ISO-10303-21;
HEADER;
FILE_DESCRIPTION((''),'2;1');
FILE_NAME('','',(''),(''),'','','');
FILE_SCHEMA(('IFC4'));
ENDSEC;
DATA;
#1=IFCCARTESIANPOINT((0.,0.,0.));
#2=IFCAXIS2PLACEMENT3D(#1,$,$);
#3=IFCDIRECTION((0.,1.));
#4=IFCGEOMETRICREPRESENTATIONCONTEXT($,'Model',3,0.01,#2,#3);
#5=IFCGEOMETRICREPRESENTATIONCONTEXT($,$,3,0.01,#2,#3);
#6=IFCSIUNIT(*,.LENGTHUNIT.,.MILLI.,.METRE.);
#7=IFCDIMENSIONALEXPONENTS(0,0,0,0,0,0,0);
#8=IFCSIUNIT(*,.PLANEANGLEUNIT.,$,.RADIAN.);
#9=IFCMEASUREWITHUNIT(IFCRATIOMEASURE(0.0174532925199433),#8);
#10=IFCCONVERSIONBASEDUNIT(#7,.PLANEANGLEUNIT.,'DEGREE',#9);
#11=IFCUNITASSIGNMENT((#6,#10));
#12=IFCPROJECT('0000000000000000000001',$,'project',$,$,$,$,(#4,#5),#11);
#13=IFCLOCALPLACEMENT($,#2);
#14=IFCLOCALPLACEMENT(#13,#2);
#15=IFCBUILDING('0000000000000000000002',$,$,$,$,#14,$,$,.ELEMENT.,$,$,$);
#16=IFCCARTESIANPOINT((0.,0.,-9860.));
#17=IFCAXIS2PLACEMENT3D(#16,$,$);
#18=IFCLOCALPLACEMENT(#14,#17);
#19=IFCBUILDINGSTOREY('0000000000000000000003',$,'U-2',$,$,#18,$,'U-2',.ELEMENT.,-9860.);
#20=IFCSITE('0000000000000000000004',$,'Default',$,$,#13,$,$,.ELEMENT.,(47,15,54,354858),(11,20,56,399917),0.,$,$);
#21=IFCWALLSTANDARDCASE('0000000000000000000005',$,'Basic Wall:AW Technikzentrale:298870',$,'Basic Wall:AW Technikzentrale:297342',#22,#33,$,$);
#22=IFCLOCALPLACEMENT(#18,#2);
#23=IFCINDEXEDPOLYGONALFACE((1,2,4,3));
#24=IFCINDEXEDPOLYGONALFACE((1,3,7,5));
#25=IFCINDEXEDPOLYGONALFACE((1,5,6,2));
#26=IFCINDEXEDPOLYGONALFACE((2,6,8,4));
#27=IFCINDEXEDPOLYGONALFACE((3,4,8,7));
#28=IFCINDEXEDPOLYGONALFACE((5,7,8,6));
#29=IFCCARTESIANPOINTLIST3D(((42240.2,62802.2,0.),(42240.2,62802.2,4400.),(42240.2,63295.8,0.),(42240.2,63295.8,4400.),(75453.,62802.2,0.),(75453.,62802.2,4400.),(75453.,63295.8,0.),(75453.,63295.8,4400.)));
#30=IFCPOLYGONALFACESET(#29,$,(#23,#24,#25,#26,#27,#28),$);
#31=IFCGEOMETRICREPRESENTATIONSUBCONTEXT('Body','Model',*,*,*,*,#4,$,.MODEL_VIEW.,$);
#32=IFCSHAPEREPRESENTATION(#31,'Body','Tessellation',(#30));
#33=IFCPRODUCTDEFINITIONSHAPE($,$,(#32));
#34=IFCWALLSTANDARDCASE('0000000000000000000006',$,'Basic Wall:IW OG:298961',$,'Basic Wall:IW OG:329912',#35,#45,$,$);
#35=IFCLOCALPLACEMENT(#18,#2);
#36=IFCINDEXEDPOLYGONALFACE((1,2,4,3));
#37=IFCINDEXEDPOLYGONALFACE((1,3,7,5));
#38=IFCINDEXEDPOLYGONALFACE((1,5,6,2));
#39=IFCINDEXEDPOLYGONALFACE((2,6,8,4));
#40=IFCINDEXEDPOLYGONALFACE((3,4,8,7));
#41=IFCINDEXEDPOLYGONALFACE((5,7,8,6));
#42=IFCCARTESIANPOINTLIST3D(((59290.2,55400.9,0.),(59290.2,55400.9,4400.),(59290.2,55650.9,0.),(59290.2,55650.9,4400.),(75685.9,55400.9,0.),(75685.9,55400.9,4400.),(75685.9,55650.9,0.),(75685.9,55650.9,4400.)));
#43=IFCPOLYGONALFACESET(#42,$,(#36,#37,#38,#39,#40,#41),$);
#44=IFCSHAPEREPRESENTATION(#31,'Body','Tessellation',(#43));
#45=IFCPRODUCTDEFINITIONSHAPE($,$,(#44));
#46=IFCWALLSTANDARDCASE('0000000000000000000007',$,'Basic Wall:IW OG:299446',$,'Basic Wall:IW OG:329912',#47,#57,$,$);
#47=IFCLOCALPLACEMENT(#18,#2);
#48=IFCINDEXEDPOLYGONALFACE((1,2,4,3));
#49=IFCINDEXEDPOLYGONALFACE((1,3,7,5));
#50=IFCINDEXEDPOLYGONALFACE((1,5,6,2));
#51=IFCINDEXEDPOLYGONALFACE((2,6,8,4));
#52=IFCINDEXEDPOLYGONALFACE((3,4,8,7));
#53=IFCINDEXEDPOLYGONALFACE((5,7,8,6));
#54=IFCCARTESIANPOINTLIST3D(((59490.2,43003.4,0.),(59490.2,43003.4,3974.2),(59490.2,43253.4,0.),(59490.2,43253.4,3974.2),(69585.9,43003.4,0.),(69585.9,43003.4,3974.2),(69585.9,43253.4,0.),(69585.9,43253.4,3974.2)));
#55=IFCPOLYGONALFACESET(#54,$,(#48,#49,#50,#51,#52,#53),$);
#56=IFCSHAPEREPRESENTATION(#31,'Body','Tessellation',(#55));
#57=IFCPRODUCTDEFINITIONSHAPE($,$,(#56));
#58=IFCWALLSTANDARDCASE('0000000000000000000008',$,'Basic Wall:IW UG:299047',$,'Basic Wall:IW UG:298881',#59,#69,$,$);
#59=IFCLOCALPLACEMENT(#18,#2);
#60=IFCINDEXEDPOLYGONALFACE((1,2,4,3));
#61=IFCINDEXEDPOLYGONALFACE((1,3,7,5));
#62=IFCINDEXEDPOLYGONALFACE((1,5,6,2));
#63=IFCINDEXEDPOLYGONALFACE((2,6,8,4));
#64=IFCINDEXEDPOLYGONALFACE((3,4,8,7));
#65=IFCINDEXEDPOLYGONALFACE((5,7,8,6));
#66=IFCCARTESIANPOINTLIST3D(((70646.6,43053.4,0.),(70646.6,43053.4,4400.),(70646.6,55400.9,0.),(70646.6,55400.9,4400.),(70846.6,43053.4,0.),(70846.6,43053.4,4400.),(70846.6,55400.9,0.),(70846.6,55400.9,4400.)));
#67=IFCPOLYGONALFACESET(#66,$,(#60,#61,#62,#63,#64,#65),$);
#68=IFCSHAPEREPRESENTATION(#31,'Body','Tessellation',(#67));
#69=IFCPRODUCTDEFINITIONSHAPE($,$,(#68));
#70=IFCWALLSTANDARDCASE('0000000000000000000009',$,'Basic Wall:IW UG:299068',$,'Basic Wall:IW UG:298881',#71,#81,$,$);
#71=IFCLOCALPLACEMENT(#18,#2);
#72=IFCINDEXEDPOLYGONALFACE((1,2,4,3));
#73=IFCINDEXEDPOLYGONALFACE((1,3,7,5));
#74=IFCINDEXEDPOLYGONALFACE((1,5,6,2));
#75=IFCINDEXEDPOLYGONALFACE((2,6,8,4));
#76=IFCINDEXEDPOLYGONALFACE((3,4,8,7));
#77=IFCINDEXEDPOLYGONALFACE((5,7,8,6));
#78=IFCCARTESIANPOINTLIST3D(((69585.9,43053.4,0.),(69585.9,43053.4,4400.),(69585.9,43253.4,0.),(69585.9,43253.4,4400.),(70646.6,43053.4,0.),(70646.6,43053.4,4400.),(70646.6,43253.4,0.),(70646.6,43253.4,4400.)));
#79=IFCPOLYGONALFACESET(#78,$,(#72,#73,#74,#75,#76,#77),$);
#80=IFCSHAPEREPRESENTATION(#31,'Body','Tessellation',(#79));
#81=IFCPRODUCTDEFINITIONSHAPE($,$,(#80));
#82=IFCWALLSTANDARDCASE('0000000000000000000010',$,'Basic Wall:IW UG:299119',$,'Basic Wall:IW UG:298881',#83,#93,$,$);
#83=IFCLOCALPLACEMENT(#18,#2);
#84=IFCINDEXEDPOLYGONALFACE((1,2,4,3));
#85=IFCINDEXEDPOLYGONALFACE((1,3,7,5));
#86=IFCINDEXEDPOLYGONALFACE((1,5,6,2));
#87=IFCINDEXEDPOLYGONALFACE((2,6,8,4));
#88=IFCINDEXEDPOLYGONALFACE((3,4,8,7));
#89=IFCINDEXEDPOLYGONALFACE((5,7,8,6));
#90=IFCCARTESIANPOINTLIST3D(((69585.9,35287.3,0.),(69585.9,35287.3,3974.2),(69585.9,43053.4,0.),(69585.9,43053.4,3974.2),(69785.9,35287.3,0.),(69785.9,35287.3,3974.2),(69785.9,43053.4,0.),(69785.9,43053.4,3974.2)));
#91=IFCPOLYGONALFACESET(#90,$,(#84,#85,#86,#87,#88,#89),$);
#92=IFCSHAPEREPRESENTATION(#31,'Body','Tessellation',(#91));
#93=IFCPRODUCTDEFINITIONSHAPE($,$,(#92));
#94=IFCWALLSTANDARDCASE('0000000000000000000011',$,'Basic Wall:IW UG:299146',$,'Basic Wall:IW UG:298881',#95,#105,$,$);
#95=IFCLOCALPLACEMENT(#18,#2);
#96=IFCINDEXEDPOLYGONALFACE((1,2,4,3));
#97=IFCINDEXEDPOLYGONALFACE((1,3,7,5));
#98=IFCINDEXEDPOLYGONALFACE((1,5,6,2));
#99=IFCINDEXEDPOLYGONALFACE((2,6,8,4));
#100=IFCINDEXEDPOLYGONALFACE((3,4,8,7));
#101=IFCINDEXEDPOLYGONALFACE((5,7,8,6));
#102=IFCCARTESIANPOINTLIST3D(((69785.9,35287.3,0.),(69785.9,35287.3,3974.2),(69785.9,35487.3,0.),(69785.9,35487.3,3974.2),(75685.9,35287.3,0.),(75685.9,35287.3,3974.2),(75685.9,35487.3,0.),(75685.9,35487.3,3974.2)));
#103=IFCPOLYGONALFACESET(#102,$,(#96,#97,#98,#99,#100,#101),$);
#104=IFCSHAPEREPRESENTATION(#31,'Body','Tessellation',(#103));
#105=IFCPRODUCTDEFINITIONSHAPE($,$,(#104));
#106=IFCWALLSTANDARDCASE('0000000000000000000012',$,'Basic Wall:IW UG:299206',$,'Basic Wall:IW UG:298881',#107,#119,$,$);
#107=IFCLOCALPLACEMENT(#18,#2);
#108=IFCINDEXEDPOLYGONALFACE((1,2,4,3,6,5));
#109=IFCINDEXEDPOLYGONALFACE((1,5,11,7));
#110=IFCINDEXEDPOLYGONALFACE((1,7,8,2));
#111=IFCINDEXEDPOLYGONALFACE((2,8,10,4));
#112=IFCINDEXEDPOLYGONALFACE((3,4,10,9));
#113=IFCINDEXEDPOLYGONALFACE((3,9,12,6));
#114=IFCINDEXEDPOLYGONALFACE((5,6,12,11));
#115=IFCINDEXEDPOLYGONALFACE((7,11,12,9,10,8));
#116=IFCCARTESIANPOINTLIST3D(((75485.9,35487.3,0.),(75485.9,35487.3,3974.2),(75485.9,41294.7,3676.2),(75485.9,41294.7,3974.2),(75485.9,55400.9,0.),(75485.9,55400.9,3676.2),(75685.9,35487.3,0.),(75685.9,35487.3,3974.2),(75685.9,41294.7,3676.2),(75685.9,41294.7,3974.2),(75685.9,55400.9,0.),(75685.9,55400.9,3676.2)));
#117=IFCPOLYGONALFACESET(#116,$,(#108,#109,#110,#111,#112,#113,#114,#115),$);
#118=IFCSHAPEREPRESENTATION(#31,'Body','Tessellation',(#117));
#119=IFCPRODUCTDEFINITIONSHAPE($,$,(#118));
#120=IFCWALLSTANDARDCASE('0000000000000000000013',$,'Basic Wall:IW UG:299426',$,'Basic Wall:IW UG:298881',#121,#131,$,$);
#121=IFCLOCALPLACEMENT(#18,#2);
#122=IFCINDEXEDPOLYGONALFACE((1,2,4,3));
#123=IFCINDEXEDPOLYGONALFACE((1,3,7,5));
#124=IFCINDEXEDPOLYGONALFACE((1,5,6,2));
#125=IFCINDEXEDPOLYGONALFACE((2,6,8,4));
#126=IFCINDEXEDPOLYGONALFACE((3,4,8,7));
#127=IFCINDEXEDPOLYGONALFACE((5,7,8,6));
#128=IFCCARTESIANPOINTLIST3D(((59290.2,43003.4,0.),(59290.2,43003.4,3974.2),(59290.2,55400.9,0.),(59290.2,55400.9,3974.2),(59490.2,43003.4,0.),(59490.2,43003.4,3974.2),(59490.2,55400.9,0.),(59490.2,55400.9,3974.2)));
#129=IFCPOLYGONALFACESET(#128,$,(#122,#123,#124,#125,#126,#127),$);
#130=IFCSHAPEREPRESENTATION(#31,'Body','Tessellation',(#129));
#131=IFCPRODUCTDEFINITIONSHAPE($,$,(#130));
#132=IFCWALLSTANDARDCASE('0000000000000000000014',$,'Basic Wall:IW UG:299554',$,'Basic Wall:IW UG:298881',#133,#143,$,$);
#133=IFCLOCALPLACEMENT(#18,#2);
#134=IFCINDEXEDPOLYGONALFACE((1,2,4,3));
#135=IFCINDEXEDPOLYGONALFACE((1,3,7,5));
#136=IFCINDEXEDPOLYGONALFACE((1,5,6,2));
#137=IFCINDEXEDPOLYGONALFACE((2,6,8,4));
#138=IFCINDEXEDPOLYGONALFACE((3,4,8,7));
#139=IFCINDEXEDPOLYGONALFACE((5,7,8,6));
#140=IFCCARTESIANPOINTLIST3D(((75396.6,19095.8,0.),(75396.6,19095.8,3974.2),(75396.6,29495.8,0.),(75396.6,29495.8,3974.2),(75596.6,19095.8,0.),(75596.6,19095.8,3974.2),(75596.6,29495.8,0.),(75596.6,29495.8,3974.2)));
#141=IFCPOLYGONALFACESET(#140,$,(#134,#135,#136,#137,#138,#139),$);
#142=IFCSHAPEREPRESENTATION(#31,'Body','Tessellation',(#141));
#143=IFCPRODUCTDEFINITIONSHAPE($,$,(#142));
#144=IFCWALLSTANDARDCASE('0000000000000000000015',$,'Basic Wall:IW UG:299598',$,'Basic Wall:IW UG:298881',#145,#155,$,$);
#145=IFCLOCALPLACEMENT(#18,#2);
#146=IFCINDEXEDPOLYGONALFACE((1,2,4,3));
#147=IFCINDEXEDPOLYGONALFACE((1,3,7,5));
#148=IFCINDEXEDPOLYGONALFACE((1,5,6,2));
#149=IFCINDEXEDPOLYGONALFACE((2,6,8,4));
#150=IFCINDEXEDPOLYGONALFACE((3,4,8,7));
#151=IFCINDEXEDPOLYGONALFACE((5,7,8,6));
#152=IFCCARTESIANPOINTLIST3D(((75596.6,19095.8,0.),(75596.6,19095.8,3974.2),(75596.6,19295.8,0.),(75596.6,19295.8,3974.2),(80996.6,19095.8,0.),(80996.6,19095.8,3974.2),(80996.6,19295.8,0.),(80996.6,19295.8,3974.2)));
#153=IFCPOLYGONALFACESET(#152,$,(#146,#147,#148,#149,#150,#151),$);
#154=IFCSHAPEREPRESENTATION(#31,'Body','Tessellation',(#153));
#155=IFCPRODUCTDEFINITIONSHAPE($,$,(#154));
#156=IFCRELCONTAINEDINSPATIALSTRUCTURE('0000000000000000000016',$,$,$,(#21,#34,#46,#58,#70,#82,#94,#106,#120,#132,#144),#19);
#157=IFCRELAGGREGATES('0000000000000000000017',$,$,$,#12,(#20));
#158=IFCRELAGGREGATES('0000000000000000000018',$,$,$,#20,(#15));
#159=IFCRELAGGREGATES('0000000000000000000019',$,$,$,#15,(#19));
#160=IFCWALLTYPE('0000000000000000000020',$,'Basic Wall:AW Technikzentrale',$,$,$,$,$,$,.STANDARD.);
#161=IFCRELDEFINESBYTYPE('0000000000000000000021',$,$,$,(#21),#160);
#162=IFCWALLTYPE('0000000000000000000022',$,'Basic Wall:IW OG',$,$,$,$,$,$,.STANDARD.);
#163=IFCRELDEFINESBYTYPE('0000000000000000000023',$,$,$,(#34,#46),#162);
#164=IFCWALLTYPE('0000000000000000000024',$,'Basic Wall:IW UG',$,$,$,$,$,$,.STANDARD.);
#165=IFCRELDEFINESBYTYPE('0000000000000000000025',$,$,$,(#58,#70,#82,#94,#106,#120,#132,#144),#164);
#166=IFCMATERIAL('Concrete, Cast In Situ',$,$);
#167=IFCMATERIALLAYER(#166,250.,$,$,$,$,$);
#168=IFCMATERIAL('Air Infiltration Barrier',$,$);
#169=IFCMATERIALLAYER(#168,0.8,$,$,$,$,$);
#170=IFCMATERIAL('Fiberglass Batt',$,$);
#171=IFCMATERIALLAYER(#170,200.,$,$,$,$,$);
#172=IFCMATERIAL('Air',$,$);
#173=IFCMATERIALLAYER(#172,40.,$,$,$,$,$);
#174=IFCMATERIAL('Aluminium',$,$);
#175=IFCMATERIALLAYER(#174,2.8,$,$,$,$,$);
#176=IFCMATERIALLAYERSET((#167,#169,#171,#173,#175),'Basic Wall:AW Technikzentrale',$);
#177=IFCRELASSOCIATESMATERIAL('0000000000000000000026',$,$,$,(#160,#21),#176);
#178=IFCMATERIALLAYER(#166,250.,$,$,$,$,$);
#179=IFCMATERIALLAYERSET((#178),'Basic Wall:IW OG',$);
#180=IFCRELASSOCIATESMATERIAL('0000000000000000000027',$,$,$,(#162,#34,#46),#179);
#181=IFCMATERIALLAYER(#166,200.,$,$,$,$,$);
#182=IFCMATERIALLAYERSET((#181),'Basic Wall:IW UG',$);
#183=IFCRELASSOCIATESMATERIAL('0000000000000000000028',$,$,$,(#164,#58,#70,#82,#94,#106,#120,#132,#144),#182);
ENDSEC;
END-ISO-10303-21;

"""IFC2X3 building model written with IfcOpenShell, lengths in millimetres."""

from ifc_helpers import new_model, entity, si_unit, converted_unit, direction, frame, frame_2d, origin, place, context, subcontext, project, spatial, polyline, rectangle, extrude, clip, bounded_halfspace, material, layer, layer_set, layer_usage, type_object, element, save


model = new_model("IFC2X3")

# Units and contexts
model_context = context("Model", 3, precision=0.01, world=origin(), true_north=direction((0.0, 1.0)))
context_of_model = context(None, 3, precision=0.01, world=origin(), true_north=direction((0.0, 1.0)))
body_context = subcontext(model_context, "Body", "Model", "MODEL_VIEW")
ifc_project = project(units=[si_unit("LENGTHUNIT", "METRE", prefix="MILLI"), converted_unit("PLANEANGLEUNIT", "DEGREE", entity("IfcRatioMeasure", 0.0174532925199433), si_unit("PLANEANGLEUNIT", "RADIAN"), dimensions=[0, 0, 0, 0, 0, 0, 0])], contexts=[model_context, context_of_model])

# Site, building, storey
site_placement = place(None, origin())
site = spatial("IfcSite", under=ifc_project, at=site_placement, Name="Default", CompositionType="ELEMENT", RefLatitude=(47, 15, 54, 354858), RefLongitude=(11, 20, 56, 399917), RefElevation=0.0)
building_placement = place(site_placement, origin())
building = spatial("IfcBuilding", under=site, at=building_placement, CompositionType="ELEMENT")
storey_placement = place(building_placement, frame((0.0, 0.0, -9860.0)))
storey = spatial("IfcBuildingStorey", under=building, at=storey_placement, Name="U-2", LongName="U-2", CompositionType="ELEMENT", Elevation=-9860.0)

# Shared definitions
ifc_material_1 = material(Name="Air Infiltration Barrier")
ifc_material_2 = material(Name="Fiberglass Batt")

# Walls
ifc_material_3 = material(Name="Concrete, Cast In Situ")
ifc_layer_1 = layer(ifc_material_3, 250.0)
ifc_layer_2 = layer(ifc_material_1, 0.8)
ifc_layer_3 = layer(ifc_material_2, 200.0)
ifc_material_4 = material(Name="Air")
ifc_layer_4 = layer(ifc_material_4, 40.0)
ifc_material_5 = material(Name="Aluminium")
ifc_layer_5 = layer(ifc_material_5, 2.8)
ifc_layer_set_1 = layer_set([ifc_layer_1, ifc_layer_2, ifc_layer_3, ifc_layer_4, ifc_layer_5], Name="Basic Wall:AW Technikzentrale")
wall_type_1 = type_object("IfcWallType", Name="Basic Wall:AW Technikzentrale", PredefinedType="STANDARD", material=ifc_layer_set_1)
ifc_layer_usage_1 = layer_usage(ifc_layer_set_1, "AXIS2", "NEGATIVE", 246.8)
wall_1_placement = place(storey_placement, frame((75453.0, 63049.0, 0.0), z_axis=(0.0, 0.0, 1.0), x_axis=(-1.0, 0.0, 0.0)))
element("IfcWallStandardCase", 1, at=wall_1_placement, inside=storey, type_object=wall_type_1, material=ifc_layer_usage_1, Name="Basic Wall:AW Technikzentrale:298870", ObjectType="Basic Wall:AW Technikzentrale:297342", context=body_context, shape_type="SweptSolid", body=[
    extrude(rectangle(XDim=33212.8, YDim=493.6, at=frame_2d((16606.4, 0.0), x_axis=(-1.0, 0.0))), origin(), (0.0, 0.0, 1.0), 4400.0),
])
ifc_layer_6 = layer(ifc_material_3, 250.0)
ifc_layer_set_2 = layer_set([ifc_layer_6], Name="Basic Wall:IW OG")
ifc_layer_usage_2 = layer_usage(ifc_layer_set_2, "AXIS2", "NEGATIVE", 125.0)
wall_type_2 = type_object("IfcWallType", Name="Basic Wall:IW OG", PredefinedType="STANDARD", material=ifc_layer_set_2)
wall_2_placement = place(storey_placement, frame((75685.9, 55525.9, 0.0), z_axis=(0.0, 0.0, 1.0), x_axis=(-1.0, 0.0, 0.0)))
element("IfcWallStandardCase", 2, at=wall_2_placement, inside=storey, type_object=wall_type_2, material=ifc_layer_usage_2, Name="Basic Wall:IW OG:298961", ObjectType="Basic Wall:IW OG:329912", context=body_context, shape_type="SweptSolid", body=[
    extrude(rectangle(XDim=16395.7, YDim=250.0, at=frame_2d((8197.9, 0.0), x_axis=(-1.0, 0.0))), origin(), (0.0, 0.0, 1.0), 4400.0),
])
ifc_layer_usage_3 = layer_usage(ifc_layer_set_2, "AXIS2", "POSITIVE", -125.0)
wall_3_placement = place(storey_placement, frame((59490.2, 43128.4, 0.0)))
element("IfcWallStandardCase", 3, at=wall_3_placement, inside=storey, type_object=wall_type_2, material=ifc_layer_usage_3, Name="Basic Wall:IW OG:299446", ObjectType="Basic Wall:IW OG:329912", context=body_context, shape_type="Clipping", body=[
    clip(extrude(rectangle(XDim=10095.7, YDim=250.0, at=frame_2d((5047.9, 0.0), x_axis=(-1.0, 0.0))), origin(), (0.0, 0.0, 1.0), 3974.2), bounded_halfspace(frame((0.0, -125.0, 3974.2), z_axis=(0.0, 0.0, -1.0), x_axis=(0.0, 1.0, 0.0)), True, frame((0.0, -125.0, 3974.2)), polyline([(0.0, 0.0), (10095.7, 0.0), (10095.7, 50.0), (10095.7, 250.0), (0.0, 250.0), (0.0, 0.0)]))),
])
ifc_layer_7 = layer(ifc_material_3, 200.0)
ifc_layer_set_3 = layer_set([ifc_layer_7], Name="Basic Wall:IW UG")
ifc_layer_usage_4 = layer_usage(ifc_layer_set_3, "AXIS2", "NEGATIVE", 100.0)
wall_type_3 = type_object("IfcWallType", Name="Basic Wall:IW UG", PredefinedType="STANDARD", material=ifc_layer_set_3)
wall_4_placement = place(storey_placement, frame((70746.6, 55400.9, 0.0), z_axis=(0.0, 0.0, 1.0), x_axis=(0.0, -1.0, 0.0)))
element("IfcWallStandardCase", 4, at=wall_4_placement, inside=storey, type_object=wall_type_3, material=ifc_layer_usage_4, Name="Basic Wall:IW UG:299047", ObjectType="Basic Wall:IW UG:298881", context=body_context, shape_type="SweptSolid", body=[
    extrude(rectangle(XDim=12347.4, YDim=200.0, at=frame_2d((6173.7, 0.0), x_axis=(-1.0, 0.0))), origin(), (0.0, 0.0, 1.0), 4400.0),
])
ifc_layer_usage_5 = layer_usage(ifc_layer_set_3, "AXIS2", "NEGATIVE", 100.0)
wall_5_placement = place(storey_placement, frame((70646.6, 43153.4, 0.0), z_axis=(0.0, 0.0, 1.0), x_axis=(-1.0, 0.0, 0.0)))
element("IfcWallStandardCase", 5, at=wall_5_placement, inside=storey, type_object=wall_type_3, material=ifc_layer_usage_5, Name="Basic Wall:IW UG:299068", ObjectType="Basic Wall:IW UG:298881", context=body_context, shape_type="SweptSolid", body=[
    extrude(rectangle(XDim=1060.7, YDim=200.0, at=frame_2d((530.3, 0.0), x_axis=(-1.0, 0.0))), origin(), (0.0, 0.0, 1.0), 4400.0),
])
ifc_layer_usage_6 = layer_usage(ifc_layer_set_3, "AXIS2", "NEGATIVE", 100.0)
wall_6_placement = place(storey_placement, frame((69685.9, 43053.4, 0.0), z_axis=(0.0, 0.0, 1.0), x_axis=(0.0, -1.0, 0.0)))
element("IfcWallStandardCase", 6, at=wall_6_placement, inside=storey, type_object=wall_type_3, material=ifc_layer_usage_6, Name="Basic Wall:IW UG:299119", ObjectType="Basic Wall:IW UG:298881", context=body_context, shape_type="Clipping", body=[
    clip(extrude(rectangle(XDim=7766.1, YDim=200.0, at=frame_2d((3883.0, 0.0), x_axis=(-1.0, 0.0))), origin(), (0.0, 0.0, 1.0), 3974.2), bounded_halfspace(frame((0.0, -100.0, 3974.2), z_axis=(0.0, 0.0, -1.0), x_axis=(-1.0, 0.0, 0.0)), True, frame((0.0, -100.0, 3974.2)), polyline([(0.0, 0.0), (50.0, 0.0), (7766.1, 0.0), (7766.1, 200.0), (7566.1, 200.0), (0.0, 200.0), (0.0, 0.0)]))),
])
ifc_layer_usage_7 = layer_usage(ifc_layer_set_3, "AXIS2", "NEGATIVE", 100.0)
wall_7_placement = place(storey_placement, frame((69785.9, 35387.3, 0.0)))
element("IfcWallStandardCase", 7, at=wall_7_placement, inside=storey, type_object=wall_type_3, material=ifc_layer_usage_7, Name="Basic Wall:IW UG:299146", ObjectType="Basic Wall:IW UG:298881", context=body_context, shape_type="Clipping", body=[
    clip(extrude(rectangle(XDim=5900.0, YDim=200.0, at=frame_2d((2950.0, 0.0), x_axis=(-1.0, 0.0))), origin(), (0.0, 0.0, 1.0), 3974.2), bounded_halfspace(frame((0.0, -100.0, 3974.2), z_axis=(0.0, 0.0, -1.0), x_axis=(0.0, 1.0, 0.0)), True, frame((0.0, -100.0, 3974.2)), polyline([(0.0, 0.0), (5900.0, 0.0), (5900.0, 200.0), (5700.0, 200.0), (0.0, 200.0), (0.0, 0.0)]))),
])
ifc_layer_usage_8 = layer_usage(ifc_layer_set_3, "AXIS2", "NEGATIVE", 100.0)
wall_8_placement = place(storey_placement, frame((75585.9, 35487.3, 0.0), z_axis=(0.0, 0.0, 1.0), x_axis=(0.0, 1.0, 0.0)))
element("IfcWallStandardCase", 8, at=wall_8_placement, inside=storey, type_object=wall_type_3, material=ifc_layer_usage_8, Name="Basic Wall:IW UG:299206", ObjectType="Basic Wall:IW UG:298881", context=body_context, shape_type="Clipping", body=[
    clip(clip(extrude(rectangle(XDim=19913.5, YDim=200.0, at=frame_2d((9956.8, 0.0), x_axis=(-1.0, 0.0))), origin(), (0.0, 0.0, 1.0), 3974.2), bounded_halfspace(frame((0.0, -100.0, 3974.2), z_axis=(0.0, 0.0, -1.0), x_axis=(1.0, 0.0, 0.0)), True, frame((0.0, -100.0, 3974.2)), polyline([(0.0, 0.0), (5807.3, 0.0), (5807.3, 200.0), (0.0, 200.0), (0.0, 0.0)]))), bounded_halfspace(frame((5807.3, -100.0, 3676.2), z_axis=(0.0, 0.0, 1.0), x_axis=(0.0, 1.0, 0.0)), False, frame((5807.3, -100.0, 3676.2)), polyline([(0.0, 0.0), (14106.2, 0.0), (14106.2, 200.0), (0.0, 200.0), (0.0, 0.0)]))),
])
ifc_layer_usage_9 = layer_usage(ifc_layer_set_3, "AXIS2", "NEGATIVE", 100.0)
wall_9_placement = place(storey_placement, frame((59390.2, 55400.9, 0.0), z_axis=(0.0, 0.0, 1.0), x_axis=(0.0, -1.0, 0.0)))
element("IfcWallStandardCase", 9, at=wall_9_placement, inside=storey, type_object=wall_type_3, material=ifc_layer_usage_9, Name="Basic Wall:IW UG:299426", ObjectType="Basic Wall:IW UG:298881", context=body_context, shape_type="Clipping", body=[
    clip(extrude(rectangle(XDim=12397.4, YDim=200.0, at=frame_2d((6198.7, 0.0), x_axis=(-1.0, 0.0))), origin(), (0.0, 0.0, 1.0), 3974.2), bounded_halfspace(frame((0.0, -100.0, 3974.2), z_axis=(0.0, 0.0, -1.0), x_axis=(-1.0, 0.0, 0.0)), True, frame((0.0, -100.0, 3974.2)), polyline([(0.0, 0.0), (12397.4, 0.0), (12397.4, 200.0), (12147.4, 200.0), (0.0, 200.0), (0.0, 0.0)]))),
])
ifc_layer_usage_10 = layer_usage(ifc_layer_set_3, "AXIS2", "NEGATIVE", 100.0)
wall_10_placement = place(storey_placement, frame((75496.6, 29495.8, 0.0), z_axis=(0.0, 0.0, 1.0), x_axis=(0.0, -1.0, 0.0)))
element("IfcWallStandardCase", 10, at=wall_10_placement, inside=storey, type_object=wall_type_3, material=ifc_layer_usage_10, Name="Basic Wall:IW UG:299554", ObjectType="Basic Wall:IW UG:298881", context=body_context, shape_type="Clipping", body=[
    clip(extrude(rectangle(XDim=10400.0, YDim=200.0, at=frame_2d((5200.0, 0.0), x_axis=(-1.0, 0.0))), origin(), (0.0, 0.0, 1.0), 3974.2), bounded_halfspace(frame((0.0, -100.0, 3974.2), z_axis=(0.0, 0.0, -1.0), x_axis=(-1.0, 0.0, 0.0)), True, frame((0.0, -100.0, 3974.2)), polyline([(0.0, 0.0), (10400.0, 0.0), (10400.0, 200.0), (10200.0, 200.0), (200.0, 200.0), (0.0, 200.0), (0.0, 0.0)]))),
])
ifc_layer_usage_11 = layer_usage(ifc_layer_set_3, "AXIS2", "NEGATIVE", 100.0)
wall_11_placement = place(storey_placement, frame((75596.6, 19195.8, 0.0)))
element("IfcWallStandardCase", 11, at=wall_11_placement, inside=storey, type_object=wall_type_3, material=ifc_layer_usage_11, Name="Basic Wall:IW UG:299598", ObjectType="Basic Wall:IW UG:298881", context=body_context, shape_type="Clipping", body=[
    clip(extrude(rectangle(XDim=5400.0, YDim=200.0, at=frame_2d((2700.0, 0.0), x_axis=(-1.0, 0.0))), origin(), (0.0, 0.0, 1.0), 3974.2), bounded_halfspace(frame((0.0, -100.0, 3974.2), z_axis=(0.0, 0.0, -1.0), x_axis=(0.0, 1.0, 0.0)), True, frame((0.0, -100.0, 3974.2)), polyline([(0.0, 0.0), (5400.0, 0.0), (5400.0, 200.0), (5200.0, 200.0), (0.0, 200.0), (0.0, 0.0)]))),
])

save(model, "model.ifc")
